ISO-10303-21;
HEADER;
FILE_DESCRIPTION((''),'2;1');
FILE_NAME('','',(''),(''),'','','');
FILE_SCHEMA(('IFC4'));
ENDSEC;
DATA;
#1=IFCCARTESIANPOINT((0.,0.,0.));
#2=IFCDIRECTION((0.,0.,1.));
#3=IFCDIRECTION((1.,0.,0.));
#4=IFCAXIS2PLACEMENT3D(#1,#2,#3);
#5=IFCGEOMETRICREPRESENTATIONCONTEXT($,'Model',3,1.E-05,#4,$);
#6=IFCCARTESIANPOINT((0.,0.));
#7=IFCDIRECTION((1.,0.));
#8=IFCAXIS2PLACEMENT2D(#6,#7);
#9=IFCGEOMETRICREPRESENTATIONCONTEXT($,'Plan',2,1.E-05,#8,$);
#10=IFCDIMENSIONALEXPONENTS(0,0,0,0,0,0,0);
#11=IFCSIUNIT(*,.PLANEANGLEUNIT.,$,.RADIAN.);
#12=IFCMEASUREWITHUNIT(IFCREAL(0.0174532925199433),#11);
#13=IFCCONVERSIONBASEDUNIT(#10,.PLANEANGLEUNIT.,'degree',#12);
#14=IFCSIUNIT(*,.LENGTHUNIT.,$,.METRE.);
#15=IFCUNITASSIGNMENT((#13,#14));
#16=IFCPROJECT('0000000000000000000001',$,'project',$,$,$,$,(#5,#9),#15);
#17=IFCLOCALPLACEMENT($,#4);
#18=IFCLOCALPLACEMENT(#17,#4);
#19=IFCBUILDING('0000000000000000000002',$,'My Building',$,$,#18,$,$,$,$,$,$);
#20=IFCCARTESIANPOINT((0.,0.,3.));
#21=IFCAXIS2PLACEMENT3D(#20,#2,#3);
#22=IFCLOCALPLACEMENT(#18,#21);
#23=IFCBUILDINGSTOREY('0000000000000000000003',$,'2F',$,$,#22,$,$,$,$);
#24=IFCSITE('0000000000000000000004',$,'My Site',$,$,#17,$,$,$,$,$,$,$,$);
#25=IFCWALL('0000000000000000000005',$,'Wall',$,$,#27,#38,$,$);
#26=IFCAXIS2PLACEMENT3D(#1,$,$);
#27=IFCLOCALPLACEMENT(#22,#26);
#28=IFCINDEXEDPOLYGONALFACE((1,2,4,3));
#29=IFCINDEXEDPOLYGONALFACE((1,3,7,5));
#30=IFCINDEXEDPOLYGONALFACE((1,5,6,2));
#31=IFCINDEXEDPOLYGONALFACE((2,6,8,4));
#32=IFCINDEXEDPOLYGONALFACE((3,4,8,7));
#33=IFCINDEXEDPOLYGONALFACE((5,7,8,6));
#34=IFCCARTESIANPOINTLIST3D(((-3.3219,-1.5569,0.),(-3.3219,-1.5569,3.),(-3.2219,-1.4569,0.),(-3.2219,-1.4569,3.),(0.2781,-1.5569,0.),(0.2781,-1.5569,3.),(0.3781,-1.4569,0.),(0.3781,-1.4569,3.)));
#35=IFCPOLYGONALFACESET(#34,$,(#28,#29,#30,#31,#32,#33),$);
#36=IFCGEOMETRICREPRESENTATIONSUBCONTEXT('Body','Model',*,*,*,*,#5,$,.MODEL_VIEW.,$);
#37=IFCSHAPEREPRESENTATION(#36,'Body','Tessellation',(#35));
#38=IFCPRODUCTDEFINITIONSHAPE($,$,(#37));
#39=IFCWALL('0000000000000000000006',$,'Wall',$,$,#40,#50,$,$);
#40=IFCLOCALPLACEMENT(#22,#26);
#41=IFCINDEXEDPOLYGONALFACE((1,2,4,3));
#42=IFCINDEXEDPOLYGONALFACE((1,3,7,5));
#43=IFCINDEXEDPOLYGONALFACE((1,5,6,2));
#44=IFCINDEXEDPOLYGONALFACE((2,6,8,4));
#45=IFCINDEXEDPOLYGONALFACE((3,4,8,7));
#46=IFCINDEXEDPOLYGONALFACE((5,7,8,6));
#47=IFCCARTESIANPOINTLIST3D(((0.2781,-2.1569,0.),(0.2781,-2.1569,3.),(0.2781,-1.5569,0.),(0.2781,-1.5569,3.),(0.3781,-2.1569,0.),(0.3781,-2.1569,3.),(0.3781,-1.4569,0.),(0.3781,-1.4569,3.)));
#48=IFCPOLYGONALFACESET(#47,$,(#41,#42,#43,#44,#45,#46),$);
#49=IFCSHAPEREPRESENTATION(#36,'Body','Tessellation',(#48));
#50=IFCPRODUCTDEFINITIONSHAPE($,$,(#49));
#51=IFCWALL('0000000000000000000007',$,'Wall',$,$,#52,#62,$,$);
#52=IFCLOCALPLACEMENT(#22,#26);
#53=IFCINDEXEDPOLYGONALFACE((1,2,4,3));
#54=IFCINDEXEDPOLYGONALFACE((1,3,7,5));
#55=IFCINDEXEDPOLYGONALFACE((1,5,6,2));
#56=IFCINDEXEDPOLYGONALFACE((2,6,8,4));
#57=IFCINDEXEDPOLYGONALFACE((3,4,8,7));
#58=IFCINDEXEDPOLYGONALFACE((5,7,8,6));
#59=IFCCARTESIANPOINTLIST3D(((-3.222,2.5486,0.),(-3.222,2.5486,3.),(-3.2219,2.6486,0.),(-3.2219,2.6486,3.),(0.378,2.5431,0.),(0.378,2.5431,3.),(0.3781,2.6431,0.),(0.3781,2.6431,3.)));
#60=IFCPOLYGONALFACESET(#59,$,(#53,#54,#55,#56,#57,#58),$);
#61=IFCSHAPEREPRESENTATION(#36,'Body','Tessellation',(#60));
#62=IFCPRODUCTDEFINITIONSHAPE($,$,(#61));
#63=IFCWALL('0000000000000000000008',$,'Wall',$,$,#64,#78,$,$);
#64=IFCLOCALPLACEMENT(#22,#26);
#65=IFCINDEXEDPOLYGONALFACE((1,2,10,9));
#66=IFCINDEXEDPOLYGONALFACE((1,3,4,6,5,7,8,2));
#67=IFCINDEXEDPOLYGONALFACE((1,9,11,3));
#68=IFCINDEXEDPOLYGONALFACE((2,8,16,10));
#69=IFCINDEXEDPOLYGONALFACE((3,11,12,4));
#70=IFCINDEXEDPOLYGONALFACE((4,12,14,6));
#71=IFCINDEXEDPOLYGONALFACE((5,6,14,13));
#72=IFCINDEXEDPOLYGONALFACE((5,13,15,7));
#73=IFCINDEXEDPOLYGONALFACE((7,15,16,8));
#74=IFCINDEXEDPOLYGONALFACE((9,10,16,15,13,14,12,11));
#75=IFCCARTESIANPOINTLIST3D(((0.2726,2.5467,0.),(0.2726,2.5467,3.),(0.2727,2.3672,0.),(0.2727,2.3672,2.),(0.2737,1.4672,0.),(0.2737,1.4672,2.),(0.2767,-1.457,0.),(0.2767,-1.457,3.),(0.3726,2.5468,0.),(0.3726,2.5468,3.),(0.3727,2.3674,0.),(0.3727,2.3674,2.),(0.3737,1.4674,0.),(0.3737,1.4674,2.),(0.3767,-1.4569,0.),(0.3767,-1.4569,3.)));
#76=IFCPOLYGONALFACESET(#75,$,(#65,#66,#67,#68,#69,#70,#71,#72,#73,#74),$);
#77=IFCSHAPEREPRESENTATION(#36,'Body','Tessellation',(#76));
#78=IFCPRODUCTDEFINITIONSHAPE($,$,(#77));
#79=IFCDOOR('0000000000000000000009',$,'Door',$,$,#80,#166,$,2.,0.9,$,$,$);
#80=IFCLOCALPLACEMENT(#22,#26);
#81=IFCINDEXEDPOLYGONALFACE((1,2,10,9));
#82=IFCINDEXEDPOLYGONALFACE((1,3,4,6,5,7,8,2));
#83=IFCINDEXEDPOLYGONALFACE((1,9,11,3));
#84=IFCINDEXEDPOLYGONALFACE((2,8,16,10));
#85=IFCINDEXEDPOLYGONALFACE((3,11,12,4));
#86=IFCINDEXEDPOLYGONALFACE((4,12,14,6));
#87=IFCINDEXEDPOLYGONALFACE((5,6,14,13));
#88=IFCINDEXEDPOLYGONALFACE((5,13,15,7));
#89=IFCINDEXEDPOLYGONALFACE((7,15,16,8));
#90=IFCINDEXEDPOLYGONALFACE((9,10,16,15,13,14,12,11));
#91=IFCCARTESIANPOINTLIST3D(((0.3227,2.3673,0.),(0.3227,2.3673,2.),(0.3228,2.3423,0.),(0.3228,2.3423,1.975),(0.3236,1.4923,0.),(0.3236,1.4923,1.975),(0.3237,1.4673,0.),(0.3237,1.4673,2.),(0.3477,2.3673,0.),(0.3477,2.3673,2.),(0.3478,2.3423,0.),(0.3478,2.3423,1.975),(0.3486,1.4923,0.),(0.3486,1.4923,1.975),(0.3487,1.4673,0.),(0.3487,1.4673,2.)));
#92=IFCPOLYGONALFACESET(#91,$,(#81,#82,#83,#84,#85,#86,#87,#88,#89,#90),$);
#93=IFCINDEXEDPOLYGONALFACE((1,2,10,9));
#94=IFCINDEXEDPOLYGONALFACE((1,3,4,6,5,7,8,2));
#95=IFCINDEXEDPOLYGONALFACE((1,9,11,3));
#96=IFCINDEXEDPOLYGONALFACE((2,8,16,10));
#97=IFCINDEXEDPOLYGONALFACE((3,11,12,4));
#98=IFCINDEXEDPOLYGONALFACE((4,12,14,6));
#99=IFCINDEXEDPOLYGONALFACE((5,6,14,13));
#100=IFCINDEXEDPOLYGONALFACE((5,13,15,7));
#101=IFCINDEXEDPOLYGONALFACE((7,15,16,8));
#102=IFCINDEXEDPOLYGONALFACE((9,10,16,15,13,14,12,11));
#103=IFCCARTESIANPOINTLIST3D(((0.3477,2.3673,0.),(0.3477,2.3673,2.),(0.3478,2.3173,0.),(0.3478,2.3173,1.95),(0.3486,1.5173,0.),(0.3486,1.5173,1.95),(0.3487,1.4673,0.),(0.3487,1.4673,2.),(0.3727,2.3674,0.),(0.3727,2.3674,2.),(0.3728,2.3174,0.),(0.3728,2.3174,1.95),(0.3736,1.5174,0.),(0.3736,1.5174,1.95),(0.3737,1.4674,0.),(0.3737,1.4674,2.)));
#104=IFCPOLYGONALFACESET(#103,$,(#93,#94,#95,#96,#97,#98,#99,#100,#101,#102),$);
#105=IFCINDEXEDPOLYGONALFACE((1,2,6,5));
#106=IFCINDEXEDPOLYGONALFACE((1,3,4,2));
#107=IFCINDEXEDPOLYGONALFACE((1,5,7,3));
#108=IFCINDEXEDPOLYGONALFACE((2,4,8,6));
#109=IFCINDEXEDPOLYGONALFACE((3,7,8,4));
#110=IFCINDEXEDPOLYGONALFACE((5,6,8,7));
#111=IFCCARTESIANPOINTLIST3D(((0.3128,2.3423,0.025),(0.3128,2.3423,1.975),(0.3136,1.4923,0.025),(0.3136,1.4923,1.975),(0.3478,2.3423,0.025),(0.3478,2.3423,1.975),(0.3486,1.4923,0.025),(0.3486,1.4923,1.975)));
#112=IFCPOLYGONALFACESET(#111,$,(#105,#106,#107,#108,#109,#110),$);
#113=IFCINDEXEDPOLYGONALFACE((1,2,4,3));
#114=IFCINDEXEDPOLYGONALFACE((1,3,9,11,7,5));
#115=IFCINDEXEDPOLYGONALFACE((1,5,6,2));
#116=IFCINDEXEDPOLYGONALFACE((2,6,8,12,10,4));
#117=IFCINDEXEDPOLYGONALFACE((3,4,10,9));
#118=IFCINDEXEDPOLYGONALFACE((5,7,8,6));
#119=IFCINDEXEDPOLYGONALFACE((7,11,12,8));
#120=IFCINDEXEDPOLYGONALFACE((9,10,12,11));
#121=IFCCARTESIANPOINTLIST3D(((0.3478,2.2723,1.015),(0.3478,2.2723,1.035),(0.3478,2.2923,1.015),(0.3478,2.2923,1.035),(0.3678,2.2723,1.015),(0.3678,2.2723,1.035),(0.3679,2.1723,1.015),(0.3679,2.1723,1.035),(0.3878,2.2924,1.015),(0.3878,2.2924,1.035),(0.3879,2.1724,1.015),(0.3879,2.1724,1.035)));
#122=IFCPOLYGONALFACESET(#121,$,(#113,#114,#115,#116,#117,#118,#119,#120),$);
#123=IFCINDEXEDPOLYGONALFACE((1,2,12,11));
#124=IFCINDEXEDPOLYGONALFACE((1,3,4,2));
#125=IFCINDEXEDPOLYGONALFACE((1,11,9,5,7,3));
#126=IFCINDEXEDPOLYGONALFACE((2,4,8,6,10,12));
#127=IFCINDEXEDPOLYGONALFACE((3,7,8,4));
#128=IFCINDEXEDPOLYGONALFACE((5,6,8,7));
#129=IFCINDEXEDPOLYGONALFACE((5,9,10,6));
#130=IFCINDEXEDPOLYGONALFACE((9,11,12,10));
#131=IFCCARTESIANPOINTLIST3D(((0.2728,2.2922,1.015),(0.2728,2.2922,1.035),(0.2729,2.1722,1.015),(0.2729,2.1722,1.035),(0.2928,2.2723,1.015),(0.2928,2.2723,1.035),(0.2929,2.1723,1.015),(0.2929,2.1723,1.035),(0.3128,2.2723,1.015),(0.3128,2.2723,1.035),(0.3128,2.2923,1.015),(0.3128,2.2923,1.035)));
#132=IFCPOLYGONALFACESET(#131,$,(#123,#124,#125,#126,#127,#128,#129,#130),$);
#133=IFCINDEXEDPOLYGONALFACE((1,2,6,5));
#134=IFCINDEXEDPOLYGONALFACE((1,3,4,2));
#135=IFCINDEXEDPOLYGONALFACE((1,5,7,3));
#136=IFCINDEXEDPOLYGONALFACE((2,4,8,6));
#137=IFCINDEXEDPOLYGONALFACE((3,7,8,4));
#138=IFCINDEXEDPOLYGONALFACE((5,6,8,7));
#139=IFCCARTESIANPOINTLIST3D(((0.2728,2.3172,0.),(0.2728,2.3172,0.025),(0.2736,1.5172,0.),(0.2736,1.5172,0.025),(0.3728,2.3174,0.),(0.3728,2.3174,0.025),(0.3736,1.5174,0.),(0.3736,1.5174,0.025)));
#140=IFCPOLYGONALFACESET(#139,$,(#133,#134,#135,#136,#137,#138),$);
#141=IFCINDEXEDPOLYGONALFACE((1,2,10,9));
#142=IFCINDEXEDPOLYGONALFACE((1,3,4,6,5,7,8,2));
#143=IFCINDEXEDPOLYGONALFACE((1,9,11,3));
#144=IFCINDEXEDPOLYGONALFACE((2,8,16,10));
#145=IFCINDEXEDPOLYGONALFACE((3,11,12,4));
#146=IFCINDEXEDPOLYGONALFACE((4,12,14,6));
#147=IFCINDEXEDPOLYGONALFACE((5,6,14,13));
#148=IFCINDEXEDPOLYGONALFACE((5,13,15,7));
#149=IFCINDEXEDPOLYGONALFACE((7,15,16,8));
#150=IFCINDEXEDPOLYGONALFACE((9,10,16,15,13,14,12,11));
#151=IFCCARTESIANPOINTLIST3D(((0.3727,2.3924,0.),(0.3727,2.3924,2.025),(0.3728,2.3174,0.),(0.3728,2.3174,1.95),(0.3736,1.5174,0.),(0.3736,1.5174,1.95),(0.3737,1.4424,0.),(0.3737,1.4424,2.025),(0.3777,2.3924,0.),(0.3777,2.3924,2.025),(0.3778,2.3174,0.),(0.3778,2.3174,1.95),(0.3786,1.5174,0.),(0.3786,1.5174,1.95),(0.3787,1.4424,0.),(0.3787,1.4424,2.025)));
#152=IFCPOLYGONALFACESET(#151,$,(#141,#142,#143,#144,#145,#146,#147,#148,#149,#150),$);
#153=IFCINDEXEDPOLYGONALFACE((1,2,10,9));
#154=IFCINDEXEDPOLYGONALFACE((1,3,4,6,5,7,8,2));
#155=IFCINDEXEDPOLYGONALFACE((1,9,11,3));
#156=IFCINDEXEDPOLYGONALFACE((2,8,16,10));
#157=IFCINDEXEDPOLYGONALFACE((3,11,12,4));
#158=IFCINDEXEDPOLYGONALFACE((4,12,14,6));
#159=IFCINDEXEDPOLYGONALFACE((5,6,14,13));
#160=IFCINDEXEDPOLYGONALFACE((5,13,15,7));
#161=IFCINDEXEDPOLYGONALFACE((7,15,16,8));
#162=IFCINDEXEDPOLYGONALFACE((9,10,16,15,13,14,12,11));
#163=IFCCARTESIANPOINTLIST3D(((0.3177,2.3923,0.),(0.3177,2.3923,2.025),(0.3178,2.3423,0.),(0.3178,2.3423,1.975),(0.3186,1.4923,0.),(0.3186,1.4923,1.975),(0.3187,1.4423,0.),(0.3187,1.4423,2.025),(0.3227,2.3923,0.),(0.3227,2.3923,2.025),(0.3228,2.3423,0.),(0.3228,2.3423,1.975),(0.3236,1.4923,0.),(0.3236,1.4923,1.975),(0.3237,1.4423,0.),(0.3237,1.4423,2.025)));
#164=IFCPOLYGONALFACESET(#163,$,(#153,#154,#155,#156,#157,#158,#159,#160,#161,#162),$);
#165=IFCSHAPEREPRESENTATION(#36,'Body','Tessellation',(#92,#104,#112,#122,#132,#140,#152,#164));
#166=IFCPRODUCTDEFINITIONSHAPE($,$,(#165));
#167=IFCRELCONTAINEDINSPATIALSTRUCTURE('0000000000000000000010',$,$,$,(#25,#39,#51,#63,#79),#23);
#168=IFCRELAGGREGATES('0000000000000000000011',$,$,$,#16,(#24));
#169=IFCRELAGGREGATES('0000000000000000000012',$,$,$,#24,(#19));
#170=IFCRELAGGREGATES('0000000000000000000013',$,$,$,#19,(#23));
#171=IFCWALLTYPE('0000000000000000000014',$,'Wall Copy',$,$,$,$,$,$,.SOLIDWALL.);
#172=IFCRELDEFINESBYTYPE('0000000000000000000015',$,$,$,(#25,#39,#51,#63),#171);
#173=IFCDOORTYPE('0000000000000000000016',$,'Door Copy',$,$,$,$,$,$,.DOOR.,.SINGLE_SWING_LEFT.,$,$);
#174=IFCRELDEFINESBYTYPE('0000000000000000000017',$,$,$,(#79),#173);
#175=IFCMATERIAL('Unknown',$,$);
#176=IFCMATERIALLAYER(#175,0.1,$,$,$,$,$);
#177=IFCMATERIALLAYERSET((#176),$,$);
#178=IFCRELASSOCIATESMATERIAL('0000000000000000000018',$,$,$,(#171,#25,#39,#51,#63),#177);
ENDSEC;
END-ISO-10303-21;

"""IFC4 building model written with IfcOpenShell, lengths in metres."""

from ifc_helpers import new_model, entity, si_unit, converted_unit, frame, origin_with_axes, origin_2d_with_axis, place, context, subcontext, project, spatial, line, indexed_curve, outline, extrude, shape, source, transform, mapped, material, layer, layer_set, layer_usage, type_object, type_shapes, element, fill, save


model = new_model("IFC4")

# Units and contexts
model_context = context("Model", 3, precision=1e-05, world=origin_with_axes())
plan_context = context("Plan", 2, precision=1e-05, world=origin_2d_with_axis())
body_context_1 = subcontext(model_context, "Body", "Model", "MODEL_VIEW")
body_context_2 = subcontext(plan_context, "Body", "Plan", "PLAN_VIEW")
ifc_project = project(units=[converted_unit("PLANEANGLEUNIT", "degree", entity("IfcReal", 0.0174532925199433), si_unit("PLANEANGLEUNIT", "RADIAN"), dimensions=[0, 0, 0, 0, 0, 0, 0]), si_unit("LENGTHUNIT", "METRE")], contexts=[model_context, plan_context])

# Site, building, storey
site_placement = place(None, origin_with_axes())
site = spatial("IfcSite", under=ifc_project, at=site_placement, Name="My Site")
building_placement = place(site_placement, origin_with_axes())
building = spatial("IfcBuilding", under=site, at=building_placement, Name="My Building")
storey_placement = place(building_placement, frame((0.0, 0.0, 3.0), z_axis=(0.0, 0.0, 1.0), x_axis=(1.0, 0.0, 0.0)))
storey = spatial("IfcBuildingStorey", under=building, at=storey_placement, Name="2F")

# Shared definitions
ifc_material = material(Name="Unknown")

# Shared definitions
ifc_layer_1 = layer(ifc_material, 0.1)
ifc_layer_set_1 = layer_set([ifc_layer_1])
wall_type = type_object("IfcWallType", Name="Wall Copy", PredefinedType="SOLIDWALL", material=ifc_layer_set_1)
shared_shape_1 = source(origin_with_axes(), body_context_1, "Body", "SweptSolid", [
    extrude(outline(indexed_curve([(0.0, 0.0), (0.9, 0.0), (0.9, 2.0), (0.0, 2.0)], segments=[line(1, 2, 3, 4, 1)])), frame((0.0, -0.6, 0.0), z_axis=(0.0, -1.0, 0.0), x_axis=(1.0, 0.0, 0.0)), (0.0, 0.0, -1.0), 1.2),
])
door_type = type_object("IfcDoorType", Name="Door Copy", OperationType="SINGLE_SWING_LEFT", PredefinedType="DOOR")
shared_shape_2 = source(origin_with_axes(), body_context_1, "Body", "SweptSolid", [
    extrude(outline(indexed_curve([(0.0, 0.0), (0.0, 2.0), (0.9, 2.0), (0.9, 0.0), (0.875, 0.0), (0.875, 1.975), (0.025, 1.975), (0.025, 0.0)], segments=[line(1, 2, 3, 4, 5, 6, 7, 8, 1)])), frame((0.0, 0.025, 0.0), z_axis=(0.0, -1.0, 0.0), x_axis=(1.0, 0.0, 0.0)), (0.0, 0.0, -1.0), 0.025),
    extrude(outline(indexed_curve([(0.0, 0.0), (0.0, 2.0), (0.9, 2.0), (0.9, 0.0), (0.85, 0.0), (0.85, 1.95), (0.05, 1.95), (0.05, 0.0)], segments=[line(1, 2, 3, 4, 5, 6, 7, 8, 1)])), frame((0.0, 0.0, 0.0), z_axis=(0.0, -1.0, 0.0), x_axis=(1.0, 0.0, 0.0)), (0.0, 0.0, -1.0), 0.025),
    extrude(outline(indexed_curve([(0.0, 0.0), (0.85, 0.0), (0.85, 0.035), (0.0, 0.035)], segments=[line(1, 2, 3, 4, 1)])), frame((0.025, 0.025, 0.025), z_axis=(0.0, 0.0, 1.0), x_axis=(1.0, 0.0, 0.0)), (0.0, 0.0, 1.0), 1.95),
    extrude(outline(indexed_curve([(0.0, 0.0), (0.0, -0.04), (-0.12, -0.04), (-0.12, -0.02), (-0.02, -0.02), (-0.02, 0.0)], segments=[line(1, 2, 3, 4, 5, 6, 1)])), frame((0.825, 0.025, 1.015), z_axis=(0.0, 0.0, 1.0), x_axis=(1.0, 0.0, 0.0)), (0.0, 0.0, 1.0), 0.02),
    extrude(outline(indexed_curve([(0.0, 0.0), (0.0, 0.04), (-0.12, 0.04), (-0.12, 0.02), (-0.02, 0.02), (-0.02, 0.0)], segments=[line(1, 2, 3, 4, 5, 6, 1)])), frame((0.825, 0.06, 1.015), z_axis=(0.0, 0.0, 1.0), x_axis=(1.0, 0.0, 0.0)), (0.0, 0.0, 1.0), 0.02),
    extrude(outline(indexed_curve([(0.0, 0.0), (0.8, 0.0), (0.8, 0.1), (0.0, 0.1)], segments=[line(1, 2, 3, 4, 1)])), frame((0.05, 0.0, 0.0), z_axis=(0.0, 0.0, 1.0), x_axis=(1.0, 0.0, 0.0)), (0.0, 0.0, 1.0), 0.025),
    extrude(outline(indexed_curve([(0.0, 0.0), (0.0, 2.025), (0.95, 2.025), (0.95, 0.0), (0.875, 0.0), (0.875, 1.95), (0.075, 1.95), (0.075, 0.0)], segments=[line(1, 2, 3, 4, 5, 6, 7, 8, 1)])), frame((-0.025, -0.005, 0.0), z_axis=(0.0, -1.0, 0.0), x_axis=(1.0, 0.0, 0.0)), (0.0, 0.0, -1.0), 0.005),
    extrude(outline(indexed_curve([(0.0, 0.0), (0.0, 2.025), (0.95, 2.025), (0.95, 0.0), (0.9, 0.0), (0.9, 1.975), (0.05, 1.975), (0.05, 0.0)], segments=[line(1, 2, 3, 4, 5, 6, 7, 8, 1)])), frame((-0.025, 0.05, 0.0), z_axis=(0.0, -1.0, 0.0), x_axis=(1.0, 0.0, 0.0)), (0.0, 0.0, -1.0), 0.005),
])
shared_shape_3 = source(origin_with_axes(), body_context_2, "Body", "Curve2D", [
    entity("IfcIndexedPolyCurve", entity("IfcCartesianPointList2D", [[0.0, 0.0], [0.0, 0.05], [0.025, 0.05], [0.025, 0.025], [0.05, 0.025], [0.05, 0.0]]), [entity("IfcLineIndex", [1, 2, 3, 4, 5, 6, 1])]),
    entity("IfcIndexedPolyCurve", entity("IfcCartesianPointList2D", [[0.9, 0.0], [0.9, 0.05], [0.875, 0.05], [0.875, 0.025], [0.85, 0.025], [0.85, 0.0]]), [entity("IfcLineIndex", [1, 2, 3, 4, 5, 6, 1])]),
    entity("IfcTrimmedCurve", entity("IfcEllipse", entity("IfcAxis2Placement2D", entity("IfcCartesianPoint", [0.06, 0.05]), entity("IfcDirection", [1.0, 0.0])), 0.815, 0.85), [entity("IfcCartesianPoint", [0.875, 0.05])], [entity("IfcCartesianPoint", [0.06, 0.9])], True, "CARTESIAN"),
    entity("IfcIndexedPolyCurve", entity("IfcCartesianPointList2D", [[0.025, 0.05], [0.06, 0.05], [0.06, 0.9], [0.025, 0.9]]), [entity("IfcLineIndex", [1, 2, 3, 4, 1])]),
])
type_shapes(door_type, [shared_shape_2, shared_shape_3])

# Walls
ifc_layer_usage_1 = layer_usage(ifc_layer_set_1, "AXIS2", "POSITIVE", 0.0)
wall_1_placement = place(storey_placement, frame((-3.3219, -1.5569, 0.0), z_axis=(0.0, 0.0, 1.0), x_axis=(1.0, 0.0, 0.0)))
element("IfcWall", 1, at=wall_1_placement, inside=storey, type_object=wall_type, material=ifc_layer_usage_1, Name="Wall", context=body_context_1, shape_type="SweptSolid", body=[
    extrude(outline(indexed_curve([(0.0, 0.0), (0.1, 0.1), (3.7, 0.1), (3.6, 0.0)], segments=[line(1, 2, 3, 4, 1)])), origin_with_axes(), (0.0, 0.0, 1.0), 3.0),
])
ifc_layer_usage_2 = layer_usage(ifc_layer_set_1, "AXIS2", "POSITIVE", 0.0)
wall_2_placement = place(storey_placement, frame((0.2781, -1.5569, 0.0), z_axis=(0.0, 0.0, 1.0), x_axis=(0.0, -1.0, 0.0)))
element("IfcWall", 2, at=wall_2_placement, inside=storey, type_object=wall_type, material=ifc_layer_usage_2, Name="Wall", context=body_context_1, shape_type="SweptSolid", body=[
    extrude(outline(indexed_curve([(0.0, 0.0), (-0.1, 0.1), (0.6, 0.1), (0.6, 0.0)], segments=[line(1, 2, 3, 4, 1)])), origin_with_axes(), (0.0, 0.0, 1.0), 3.0),
])
ifc_layer_usage_3 = layer_usage(ifc_layer_set_1, "AXIS2", "POSITIVE", 0.0)
wall_3_placement = place(storey_placement, frame((0.3781, 2.6431, 0.0), z_axis=(0.0, 0.0, 1.0), x_axis=(-0.999999, 0.001521, 0.0)))
element("IfcWall", 3, at=wall_3_placement, inside=storey, type_object=wall_type, material=ifc_layer_usage_3, Name="Wall", context=body_context_1, shape_type="SweptSolid", body=[
    extrude(outline(indexed_curve([(0.0, 0.0), (0.0, 0.1), (3.6, 0.1), (3.6, 0.0)], segments=[line(1, 2, 3, 4, 1)])), origin_with_axes(), (0.0, 0.0, 1.0), 3.0),
])

# Wall, opening, door
ifc_layer_usage_4 = layer_usage(ifc_layer_set_1, "AXIS2", "POSITIVE", 0.0)
wall_4_placement = place(storey_placement, frame((0.3767, -1.4569, 0.0), z_axis=(0.0, 0.0, 1.0), x_axis=(-0.001028, 0.999999, 0.0)))
wall_4 = element("IfcWall", 4, at=wall_4_placement, inside=storey, type_object=wall_type, material=ifc_layer_usage_4, Name="Wall", context=body_context_1, shape_type="SweptSolid", body=[
    extrude(outline(indexed_curve([(0.0, 0.0), (0.0, 0.1), (4.0037, 0.1), (4.0037, 0.0)], segments=[line(1, 2, 3, 4, 1)])), origin_with_axes(), (0.0, 0.0, 1.0), 3.0),
])
opening_1_placement = place(wall_4_placement, frame((2.9242, 0.0, 0.0), z_axis=(0.0, 0.0, 1.0), x_axis=(1.0, 0.0, 0.0)))
opening_1 = element("IfcOpeningElement", 5, at=opening_1_placement, cuts=wall_4, PredefinedType="OPENING", context=body_context_1, shape_type="MappedRepresentation", body=[
    mapped(shared_shape_1, transform((0.0, 0.0, 0.0), x_axis=(1.0, 0.0, 0.0), y_axis=(0.0, 1.0, 0.0), z_axis=(0.0, 0.0, 1.0), scale=1.0)),
])
door_1_placement = place(opening_1_placement, frame((0.0, 0.0, 0.0), z_axis=(0.0, 0.0, 1.0), x_axis=(1.0, 0.0, 0.0)))
door_1 = element("IfcDoor", 6, at=door_1_placement, inside=storey, type_object=door_type, Name="Door", OverallHeight=2.0, OverallWidth=0.9, shapes=[
    shape(body_context_1, "Body", "MappedRepresentation", [mapped(shared_shape_2, transform((0.0, 0.0, 0.0), x_axis=(1.0, 0.0, 0.0), y_axis=(0.0, 1.0, 0.0), z_axis=(0.0, 0.0, 1.0), scale=1.0))]),
    shape(body_context_2, "Body", "MappedRepresentation", [mapped(shared_shape_3, transform((0.0, 0.0, 0.0), x_axis=(1.0, 0.0, 0.0), y_axis=(0.0, 1.0, 0.0), z_axis=(0.0, 0.0, 1.0), scale=1.0))]),
])
fill(opening_1, door_1)

save(model, "model.ifc")
